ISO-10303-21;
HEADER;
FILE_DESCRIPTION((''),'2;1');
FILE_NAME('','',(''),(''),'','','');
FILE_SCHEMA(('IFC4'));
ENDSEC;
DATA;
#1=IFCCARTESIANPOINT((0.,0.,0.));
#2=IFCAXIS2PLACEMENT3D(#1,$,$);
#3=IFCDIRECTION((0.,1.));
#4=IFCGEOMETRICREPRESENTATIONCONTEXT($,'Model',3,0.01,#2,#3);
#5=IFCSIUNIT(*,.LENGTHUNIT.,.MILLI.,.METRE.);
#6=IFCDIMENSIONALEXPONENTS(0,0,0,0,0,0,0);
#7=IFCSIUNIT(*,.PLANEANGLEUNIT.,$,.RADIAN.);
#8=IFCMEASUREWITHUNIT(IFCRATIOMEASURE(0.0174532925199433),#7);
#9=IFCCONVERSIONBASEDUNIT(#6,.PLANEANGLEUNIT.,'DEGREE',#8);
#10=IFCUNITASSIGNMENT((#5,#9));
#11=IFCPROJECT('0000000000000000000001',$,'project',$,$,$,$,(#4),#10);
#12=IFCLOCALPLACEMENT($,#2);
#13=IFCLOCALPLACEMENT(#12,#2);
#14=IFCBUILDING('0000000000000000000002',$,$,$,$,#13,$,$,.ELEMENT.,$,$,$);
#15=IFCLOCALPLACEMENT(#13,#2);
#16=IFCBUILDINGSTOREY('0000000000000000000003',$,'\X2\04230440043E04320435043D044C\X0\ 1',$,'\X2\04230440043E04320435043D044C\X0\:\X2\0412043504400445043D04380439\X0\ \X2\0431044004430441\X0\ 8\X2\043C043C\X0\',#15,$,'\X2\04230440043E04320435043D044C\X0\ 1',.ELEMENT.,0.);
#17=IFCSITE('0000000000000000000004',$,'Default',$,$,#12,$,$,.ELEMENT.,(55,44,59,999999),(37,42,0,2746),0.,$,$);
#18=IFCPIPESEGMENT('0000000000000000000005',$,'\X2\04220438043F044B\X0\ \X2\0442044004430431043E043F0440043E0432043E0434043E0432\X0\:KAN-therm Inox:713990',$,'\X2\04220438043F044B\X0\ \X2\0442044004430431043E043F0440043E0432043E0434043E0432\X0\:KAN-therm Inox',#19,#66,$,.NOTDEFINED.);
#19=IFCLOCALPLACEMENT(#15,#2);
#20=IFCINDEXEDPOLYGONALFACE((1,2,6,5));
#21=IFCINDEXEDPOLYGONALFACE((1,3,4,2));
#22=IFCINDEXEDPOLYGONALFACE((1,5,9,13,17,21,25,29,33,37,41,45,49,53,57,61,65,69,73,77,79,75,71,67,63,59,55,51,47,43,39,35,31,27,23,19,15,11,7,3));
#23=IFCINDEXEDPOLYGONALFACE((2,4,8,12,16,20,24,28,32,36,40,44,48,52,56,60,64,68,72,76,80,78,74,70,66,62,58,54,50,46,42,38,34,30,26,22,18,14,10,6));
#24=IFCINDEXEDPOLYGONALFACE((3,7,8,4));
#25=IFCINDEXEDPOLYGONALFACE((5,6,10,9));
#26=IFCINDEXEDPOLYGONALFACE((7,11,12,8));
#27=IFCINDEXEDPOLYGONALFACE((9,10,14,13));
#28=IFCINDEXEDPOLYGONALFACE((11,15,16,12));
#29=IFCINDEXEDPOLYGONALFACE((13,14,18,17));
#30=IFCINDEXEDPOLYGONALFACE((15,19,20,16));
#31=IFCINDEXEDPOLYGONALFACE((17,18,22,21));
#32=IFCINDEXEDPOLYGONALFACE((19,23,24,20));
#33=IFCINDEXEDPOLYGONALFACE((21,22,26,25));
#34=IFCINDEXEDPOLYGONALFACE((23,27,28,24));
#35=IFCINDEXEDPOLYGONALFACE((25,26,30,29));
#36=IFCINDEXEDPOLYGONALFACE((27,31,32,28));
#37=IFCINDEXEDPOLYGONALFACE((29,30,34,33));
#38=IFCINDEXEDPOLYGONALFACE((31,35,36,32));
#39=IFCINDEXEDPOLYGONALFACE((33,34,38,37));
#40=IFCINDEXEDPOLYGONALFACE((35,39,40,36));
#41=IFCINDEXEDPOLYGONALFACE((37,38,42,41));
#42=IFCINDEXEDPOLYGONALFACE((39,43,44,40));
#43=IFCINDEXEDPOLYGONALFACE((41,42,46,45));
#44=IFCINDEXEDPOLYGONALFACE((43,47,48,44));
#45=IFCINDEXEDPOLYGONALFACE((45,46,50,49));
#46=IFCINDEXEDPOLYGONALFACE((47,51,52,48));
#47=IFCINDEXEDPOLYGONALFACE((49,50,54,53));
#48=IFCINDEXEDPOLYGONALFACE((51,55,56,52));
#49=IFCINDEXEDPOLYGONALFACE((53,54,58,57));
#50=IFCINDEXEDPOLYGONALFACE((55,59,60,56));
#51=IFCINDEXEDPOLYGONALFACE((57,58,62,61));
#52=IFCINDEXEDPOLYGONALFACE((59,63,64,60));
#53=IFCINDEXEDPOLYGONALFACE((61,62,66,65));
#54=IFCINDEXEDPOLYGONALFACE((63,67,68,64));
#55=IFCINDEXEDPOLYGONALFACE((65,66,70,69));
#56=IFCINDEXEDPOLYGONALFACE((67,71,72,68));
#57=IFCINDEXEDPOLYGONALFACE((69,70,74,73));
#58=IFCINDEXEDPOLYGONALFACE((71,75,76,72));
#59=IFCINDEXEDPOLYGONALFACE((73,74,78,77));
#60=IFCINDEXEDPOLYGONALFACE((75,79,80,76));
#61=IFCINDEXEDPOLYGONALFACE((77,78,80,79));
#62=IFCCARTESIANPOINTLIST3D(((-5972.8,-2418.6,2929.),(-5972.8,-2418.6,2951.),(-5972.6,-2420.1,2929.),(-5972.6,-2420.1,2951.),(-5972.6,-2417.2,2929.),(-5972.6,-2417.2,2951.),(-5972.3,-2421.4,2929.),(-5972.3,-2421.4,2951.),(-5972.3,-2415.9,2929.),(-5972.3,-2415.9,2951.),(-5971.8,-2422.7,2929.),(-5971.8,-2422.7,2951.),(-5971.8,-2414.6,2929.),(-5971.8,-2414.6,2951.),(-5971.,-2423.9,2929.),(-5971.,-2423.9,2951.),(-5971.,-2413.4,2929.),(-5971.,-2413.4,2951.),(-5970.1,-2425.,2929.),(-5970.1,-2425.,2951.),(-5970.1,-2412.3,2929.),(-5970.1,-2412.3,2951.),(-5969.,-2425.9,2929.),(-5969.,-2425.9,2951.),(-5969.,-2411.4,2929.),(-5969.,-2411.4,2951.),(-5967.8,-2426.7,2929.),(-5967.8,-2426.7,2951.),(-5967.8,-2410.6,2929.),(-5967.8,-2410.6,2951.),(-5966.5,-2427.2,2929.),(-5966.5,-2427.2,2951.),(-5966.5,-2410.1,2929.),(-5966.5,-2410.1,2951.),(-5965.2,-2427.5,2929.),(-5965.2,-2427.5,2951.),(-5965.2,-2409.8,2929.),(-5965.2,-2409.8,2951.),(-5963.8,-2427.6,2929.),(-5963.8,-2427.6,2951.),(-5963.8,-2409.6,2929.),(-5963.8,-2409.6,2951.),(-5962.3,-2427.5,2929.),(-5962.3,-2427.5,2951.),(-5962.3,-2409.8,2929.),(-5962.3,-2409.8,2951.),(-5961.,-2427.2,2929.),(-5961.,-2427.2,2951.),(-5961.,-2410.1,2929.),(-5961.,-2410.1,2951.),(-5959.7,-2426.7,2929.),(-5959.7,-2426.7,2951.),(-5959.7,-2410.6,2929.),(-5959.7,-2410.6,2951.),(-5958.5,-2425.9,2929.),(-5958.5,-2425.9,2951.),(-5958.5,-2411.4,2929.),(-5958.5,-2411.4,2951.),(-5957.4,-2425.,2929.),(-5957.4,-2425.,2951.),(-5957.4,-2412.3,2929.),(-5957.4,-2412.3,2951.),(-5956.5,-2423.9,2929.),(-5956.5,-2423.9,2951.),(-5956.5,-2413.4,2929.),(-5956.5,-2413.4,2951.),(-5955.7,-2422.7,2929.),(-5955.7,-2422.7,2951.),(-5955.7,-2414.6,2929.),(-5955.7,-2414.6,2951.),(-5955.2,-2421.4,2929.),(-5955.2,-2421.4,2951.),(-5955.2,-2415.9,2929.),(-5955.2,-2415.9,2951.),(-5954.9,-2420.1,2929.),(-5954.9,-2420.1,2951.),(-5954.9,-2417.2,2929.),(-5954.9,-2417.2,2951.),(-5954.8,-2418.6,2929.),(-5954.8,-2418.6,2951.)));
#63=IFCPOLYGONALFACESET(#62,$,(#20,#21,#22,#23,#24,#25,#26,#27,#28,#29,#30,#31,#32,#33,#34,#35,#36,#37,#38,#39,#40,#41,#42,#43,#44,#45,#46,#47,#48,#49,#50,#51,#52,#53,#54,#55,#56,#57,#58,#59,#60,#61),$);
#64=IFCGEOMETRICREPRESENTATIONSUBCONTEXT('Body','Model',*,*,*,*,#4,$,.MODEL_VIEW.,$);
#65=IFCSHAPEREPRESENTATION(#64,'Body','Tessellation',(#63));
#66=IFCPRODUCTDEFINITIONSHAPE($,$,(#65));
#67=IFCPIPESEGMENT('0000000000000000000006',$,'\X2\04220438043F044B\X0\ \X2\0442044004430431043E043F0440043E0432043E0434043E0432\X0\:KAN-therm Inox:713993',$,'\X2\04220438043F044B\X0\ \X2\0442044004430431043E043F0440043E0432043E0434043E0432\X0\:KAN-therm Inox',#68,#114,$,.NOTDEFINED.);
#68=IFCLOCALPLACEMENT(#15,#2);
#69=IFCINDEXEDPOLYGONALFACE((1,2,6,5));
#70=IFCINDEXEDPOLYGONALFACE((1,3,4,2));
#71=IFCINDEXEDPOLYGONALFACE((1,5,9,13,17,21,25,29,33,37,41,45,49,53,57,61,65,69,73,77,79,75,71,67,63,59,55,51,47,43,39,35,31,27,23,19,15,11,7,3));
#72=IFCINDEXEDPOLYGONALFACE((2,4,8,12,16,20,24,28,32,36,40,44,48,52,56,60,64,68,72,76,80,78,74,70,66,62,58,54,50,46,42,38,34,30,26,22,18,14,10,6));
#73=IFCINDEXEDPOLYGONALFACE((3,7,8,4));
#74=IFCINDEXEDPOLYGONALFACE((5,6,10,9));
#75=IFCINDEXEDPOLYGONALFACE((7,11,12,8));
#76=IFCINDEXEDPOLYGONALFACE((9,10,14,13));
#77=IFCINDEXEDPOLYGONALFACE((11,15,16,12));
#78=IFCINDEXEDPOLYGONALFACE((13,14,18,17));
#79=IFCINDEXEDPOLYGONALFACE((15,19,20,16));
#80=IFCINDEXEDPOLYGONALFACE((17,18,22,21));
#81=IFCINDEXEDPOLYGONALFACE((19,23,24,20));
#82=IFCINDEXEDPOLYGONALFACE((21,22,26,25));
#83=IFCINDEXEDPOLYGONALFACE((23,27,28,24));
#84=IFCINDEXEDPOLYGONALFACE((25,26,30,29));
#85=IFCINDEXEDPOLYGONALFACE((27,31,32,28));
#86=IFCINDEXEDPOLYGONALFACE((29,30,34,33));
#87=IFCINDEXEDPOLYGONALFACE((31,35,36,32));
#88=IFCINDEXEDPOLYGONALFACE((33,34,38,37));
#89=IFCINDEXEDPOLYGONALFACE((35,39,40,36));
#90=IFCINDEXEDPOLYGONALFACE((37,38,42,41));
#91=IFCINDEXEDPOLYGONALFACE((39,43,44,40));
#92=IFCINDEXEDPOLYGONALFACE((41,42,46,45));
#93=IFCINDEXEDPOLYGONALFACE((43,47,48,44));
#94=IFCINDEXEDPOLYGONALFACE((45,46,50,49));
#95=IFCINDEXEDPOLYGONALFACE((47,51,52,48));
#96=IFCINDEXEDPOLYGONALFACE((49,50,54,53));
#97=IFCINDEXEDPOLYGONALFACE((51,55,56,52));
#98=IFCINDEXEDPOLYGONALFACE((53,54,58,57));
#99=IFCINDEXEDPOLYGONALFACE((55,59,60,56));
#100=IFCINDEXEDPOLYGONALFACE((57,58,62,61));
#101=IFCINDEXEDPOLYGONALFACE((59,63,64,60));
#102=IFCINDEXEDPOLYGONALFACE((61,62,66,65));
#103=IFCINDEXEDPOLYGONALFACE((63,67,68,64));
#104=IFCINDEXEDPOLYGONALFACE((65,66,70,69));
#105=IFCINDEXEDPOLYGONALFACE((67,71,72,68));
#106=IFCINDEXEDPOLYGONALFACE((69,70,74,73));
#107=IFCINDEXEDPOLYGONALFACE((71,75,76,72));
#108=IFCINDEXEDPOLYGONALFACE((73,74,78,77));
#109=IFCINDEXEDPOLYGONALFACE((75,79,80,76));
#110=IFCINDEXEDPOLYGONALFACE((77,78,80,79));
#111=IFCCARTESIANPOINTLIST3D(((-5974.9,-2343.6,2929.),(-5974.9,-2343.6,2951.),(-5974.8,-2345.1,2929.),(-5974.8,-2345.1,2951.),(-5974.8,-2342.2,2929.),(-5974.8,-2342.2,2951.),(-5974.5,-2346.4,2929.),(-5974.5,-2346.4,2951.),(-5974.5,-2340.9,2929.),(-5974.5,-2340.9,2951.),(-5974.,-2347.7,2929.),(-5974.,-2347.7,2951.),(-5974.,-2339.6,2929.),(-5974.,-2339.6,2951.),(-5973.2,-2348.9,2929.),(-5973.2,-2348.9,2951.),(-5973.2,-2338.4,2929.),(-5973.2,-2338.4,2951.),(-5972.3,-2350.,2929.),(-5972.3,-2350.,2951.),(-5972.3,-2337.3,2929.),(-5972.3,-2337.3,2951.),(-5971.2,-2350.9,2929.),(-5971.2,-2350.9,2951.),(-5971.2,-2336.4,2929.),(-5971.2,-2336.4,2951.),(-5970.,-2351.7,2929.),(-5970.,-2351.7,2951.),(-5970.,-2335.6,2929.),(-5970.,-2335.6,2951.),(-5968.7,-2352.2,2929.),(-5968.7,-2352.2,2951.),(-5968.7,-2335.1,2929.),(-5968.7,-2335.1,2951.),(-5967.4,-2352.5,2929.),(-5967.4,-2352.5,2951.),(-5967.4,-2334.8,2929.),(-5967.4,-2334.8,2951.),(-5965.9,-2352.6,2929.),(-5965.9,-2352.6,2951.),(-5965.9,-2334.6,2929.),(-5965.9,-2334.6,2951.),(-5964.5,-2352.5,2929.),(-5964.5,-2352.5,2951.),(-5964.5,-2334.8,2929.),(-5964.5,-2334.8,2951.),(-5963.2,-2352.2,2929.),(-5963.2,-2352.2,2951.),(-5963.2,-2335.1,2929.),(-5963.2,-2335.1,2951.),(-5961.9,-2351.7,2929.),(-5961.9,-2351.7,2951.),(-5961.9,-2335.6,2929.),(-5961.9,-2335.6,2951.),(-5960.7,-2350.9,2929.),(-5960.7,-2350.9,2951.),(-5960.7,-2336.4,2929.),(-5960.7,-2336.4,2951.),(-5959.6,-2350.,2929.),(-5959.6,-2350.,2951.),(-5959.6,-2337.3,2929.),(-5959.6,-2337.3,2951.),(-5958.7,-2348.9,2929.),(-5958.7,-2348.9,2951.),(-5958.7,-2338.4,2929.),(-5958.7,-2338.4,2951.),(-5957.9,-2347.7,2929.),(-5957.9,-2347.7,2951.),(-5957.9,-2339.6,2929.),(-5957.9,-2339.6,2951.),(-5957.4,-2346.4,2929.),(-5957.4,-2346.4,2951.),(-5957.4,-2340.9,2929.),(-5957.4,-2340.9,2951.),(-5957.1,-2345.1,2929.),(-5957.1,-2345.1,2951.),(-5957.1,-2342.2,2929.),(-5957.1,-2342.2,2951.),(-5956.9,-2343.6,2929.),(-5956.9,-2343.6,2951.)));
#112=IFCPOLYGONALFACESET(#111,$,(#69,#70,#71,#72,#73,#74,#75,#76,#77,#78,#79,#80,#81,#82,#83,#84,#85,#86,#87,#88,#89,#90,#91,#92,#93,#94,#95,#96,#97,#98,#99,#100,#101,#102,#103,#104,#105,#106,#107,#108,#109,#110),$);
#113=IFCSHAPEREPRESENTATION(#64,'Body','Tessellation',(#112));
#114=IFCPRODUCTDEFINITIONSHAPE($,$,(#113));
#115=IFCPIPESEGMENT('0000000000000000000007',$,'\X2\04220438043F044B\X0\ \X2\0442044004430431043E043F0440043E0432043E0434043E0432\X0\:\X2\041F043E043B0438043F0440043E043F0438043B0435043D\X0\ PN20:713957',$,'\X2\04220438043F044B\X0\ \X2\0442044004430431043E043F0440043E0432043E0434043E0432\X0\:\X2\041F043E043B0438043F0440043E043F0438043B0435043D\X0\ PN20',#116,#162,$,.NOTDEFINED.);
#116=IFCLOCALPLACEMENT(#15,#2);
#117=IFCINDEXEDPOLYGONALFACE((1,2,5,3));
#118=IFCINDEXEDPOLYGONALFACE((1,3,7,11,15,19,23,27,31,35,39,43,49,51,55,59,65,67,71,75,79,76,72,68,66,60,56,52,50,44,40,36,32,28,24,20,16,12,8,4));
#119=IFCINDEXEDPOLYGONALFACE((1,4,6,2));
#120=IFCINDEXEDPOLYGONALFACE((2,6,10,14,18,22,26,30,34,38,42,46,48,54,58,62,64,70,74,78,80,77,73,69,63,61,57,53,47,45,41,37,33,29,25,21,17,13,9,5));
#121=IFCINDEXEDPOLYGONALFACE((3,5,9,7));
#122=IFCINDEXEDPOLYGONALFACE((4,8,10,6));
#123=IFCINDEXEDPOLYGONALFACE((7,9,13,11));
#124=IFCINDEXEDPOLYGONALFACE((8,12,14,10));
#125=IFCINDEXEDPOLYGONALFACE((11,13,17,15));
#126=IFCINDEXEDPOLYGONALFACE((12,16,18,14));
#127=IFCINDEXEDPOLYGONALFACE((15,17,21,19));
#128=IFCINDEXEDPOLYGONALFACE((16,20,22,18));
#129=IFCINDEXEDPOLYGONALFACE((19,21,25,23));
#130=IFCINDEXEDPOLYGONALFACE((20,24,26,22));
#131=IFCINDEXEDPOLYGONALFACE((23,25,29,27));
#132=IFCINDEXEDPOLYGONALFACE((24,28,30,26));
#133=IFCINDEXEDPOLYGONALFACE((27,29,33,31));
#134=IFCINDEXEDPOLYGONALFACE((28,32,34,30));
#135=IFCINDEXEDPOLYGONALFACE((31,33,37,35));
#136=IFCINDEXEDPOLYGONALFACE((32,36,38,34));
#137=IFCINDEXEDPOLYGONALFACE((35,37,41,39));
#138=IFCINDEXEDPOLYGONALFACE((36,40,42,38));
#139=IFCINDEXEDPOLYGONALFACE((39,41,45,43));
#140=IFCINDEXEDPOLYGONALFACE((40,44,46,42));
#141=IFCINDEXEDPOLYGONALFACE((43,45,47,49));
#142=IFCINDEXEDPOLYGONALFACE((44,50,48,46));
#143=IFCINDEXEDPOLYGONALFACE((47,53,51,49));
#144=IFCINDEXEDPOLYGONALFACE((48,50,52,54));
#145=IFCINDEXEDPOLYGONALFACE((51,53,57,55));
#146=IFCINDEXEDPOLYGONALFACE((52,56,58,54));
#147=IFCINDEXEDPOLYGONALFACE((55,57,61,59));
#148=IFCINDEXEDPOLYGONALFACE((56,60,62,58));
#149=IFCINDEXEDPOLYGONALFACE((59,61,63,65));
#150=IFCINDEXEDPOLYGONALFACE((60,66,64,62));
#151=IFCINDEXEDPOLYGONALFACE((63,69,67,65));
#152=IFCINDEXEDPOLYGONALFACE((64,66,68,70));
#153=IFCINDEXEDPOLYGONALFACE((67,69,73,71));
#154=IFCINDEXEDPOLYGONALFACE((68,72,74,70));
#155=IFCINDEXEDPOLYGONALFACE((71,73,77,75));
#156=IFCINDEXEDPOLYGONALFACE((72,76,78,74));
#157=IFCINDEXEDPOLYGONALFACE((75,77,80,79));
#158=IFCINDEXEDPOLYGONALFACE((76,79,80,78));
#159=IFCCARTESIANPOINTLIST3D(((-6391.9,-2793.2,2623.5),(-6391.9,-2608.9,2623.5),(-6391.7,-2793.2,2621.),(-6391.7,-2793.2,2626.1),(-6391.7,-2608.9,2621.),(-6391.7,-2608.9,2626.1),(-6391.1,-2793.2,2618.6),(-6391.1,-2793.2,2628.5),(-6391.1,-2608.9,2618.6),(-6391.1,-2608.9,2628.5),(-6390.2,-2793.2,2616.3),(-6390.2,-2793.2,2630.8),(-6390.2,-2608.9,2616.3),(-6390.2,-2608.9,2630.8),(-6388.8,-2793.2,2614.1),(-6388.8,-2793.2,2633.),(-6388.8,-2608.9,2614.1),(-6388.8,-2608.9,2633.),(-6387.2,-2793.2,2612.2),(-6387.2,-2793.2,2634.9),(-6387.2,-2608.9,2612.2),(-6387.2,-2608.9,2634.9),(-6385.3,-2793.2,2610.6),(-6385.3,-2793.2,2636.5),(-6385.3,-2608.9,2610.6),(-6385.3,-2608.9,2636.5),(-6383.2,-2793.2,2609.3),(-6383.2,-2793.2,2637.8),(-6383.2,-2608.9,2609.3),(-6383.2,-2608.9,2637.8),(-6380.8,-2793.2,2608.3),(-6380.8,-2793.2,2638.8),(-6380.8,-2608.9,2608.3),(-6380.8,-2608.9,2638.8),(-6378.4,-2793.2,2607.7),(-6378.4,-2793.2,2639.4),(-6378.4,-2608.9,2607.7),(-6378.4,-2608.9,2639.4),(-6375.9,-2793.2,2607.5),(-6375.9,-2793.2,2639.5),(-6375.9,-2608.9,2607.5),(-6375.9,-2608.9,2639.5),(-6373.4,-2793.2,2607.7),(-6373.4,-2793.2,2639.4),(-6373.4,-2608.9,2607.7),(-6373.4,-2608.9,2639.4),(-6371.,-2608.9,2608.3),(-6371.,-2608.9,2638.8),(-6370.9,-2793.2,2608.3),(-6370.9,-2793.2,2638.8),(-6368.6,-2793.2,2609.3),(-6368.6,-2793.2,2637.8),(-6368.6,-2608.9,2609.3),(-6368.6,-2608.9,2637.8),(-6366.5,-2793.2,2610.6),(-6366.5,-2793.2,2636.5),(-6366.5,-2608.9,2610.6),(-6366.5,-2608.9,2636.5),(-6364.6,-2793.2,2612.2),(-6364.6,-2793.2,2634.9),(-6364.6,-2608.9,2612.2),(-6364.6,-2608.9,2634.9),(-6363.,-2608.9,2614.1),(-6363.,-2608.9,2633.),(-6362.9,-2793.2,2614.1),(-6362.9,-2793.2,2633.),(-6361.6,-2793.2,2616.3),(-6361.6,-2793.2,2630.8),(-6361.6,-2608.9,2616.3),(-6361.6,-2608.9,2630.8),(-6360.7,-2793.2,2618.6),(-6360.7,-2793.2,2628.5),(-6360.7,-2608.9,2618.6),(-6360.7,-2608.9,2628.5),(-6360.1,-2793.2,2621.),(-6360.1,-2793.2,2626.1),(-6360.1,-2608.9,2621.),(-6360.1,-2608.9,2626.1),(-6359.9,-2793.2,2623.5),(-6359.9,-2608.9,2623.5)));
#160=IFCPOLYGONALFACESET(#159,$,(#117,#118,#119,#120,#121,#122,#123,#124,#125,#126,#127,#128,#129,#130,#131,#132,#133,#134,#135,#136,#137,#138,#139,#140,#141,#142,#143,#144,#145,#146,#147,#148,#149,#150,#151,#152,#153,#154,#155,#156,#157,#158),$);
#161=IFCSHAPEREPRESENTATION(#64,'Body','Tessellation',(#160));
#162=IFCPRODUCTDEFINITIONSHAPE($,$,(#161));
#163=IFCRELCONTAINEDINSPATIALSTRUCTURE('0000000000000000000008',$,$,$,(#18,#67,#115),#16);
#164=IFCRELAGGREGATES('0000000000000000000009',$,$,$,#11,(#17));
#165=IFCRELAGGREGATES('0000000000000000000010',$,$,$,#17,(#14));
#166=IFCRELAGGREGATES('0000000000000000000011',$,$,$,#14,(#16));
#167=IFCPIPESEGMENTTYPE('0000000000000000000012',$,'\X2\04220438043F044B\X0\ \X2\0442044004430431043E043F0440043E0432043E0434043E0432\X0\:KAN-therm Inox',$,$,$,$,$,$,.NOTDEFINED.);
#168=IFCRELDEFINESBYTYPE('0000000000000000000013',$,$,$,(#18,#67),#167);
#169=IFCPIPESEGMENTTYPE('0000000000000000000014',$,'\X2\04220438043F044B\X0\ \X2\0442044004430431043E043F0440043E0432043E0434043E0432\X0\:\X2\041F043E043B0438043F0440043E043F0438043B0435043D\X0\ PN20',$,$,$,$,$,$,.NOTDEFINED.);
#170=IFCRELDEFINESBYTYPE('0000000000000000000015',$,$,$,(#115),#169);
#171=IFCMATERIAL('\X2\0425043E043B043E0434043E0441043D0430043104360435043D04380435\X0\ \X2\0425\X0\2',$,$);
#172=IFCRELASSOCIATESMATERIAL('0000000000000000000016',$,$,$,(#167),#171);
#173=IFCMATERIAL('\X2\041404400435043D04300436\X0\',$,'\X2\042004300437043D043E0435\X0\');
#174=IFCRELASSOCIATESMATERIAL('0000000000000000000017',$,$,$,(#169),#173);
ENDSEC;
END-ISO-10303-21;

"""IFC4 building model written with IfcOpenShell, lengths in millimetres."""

from ifc_helpers import new_model, entity, si_unit, converted_unit, direction, frame, origin, place, context, subcontext, project, spatial, indexed_curve, outline, extrude, material, type_object, element, save


model = new_model("IFC4")

# Units and contexts
model_context = context("Model", 3, precision=0.01, world=origin(), true_north=direction((0.0, 1.0)))
body_context = subcontext(model_context, "Body", "Model", "MODEL_VIEW")
ifc_project = project(units=[si_unit("LENGTHUNIT", "METRE", prefix="MILLI"), converted_unit("PLANEANGLEUNIT", "DEGREE", entity("IfcRatioMeasure", 0.0174532925199433), si_unit("PLANEANGLEUNIT", "RADIAN"), dimensions=[0, 0, 0, 0, 0, 0, 0])], contexts=[model_context])

# Site, building, storey
site_placement = place(None, origin())
site = spatial("IfcSite", under=ifc_project, at=site_placement, Name="Default", CompositionType="ELEMENT", RefLatitude=(55, 44, 59, 999999), RefLongitude=(37, 42, 0, 2746), RefElevation=0.0)
building_placement = place(site_placement, origin())
building = spatial("IfcBuilding", under=site, at=building_placement, CompositionType="ELEMENT")
storey_placement = place(building_placement, origin())
storey = spatial("IfcBuildingStorey", under=building, at=storey_placement, Name="Уровень 1", ObjectType="Уровень:Верхний брус 8мм", LongName="Уровень 1", CompositionType="ELEMENT", Elevation=0.0)

# Shared definitions
ifc_material_1 = material(Name="Холодоснабжение Х2")

# Shared definitions
pipe_segment_type_1 = type_object("IfcPipeSegmentType", Name="Типы трубопроводов:KAN-therm Inox", PredefinedType="NOTDEFINED", material=ifc_material_1)

# Pipe segments
pipe_segment_1_placement = place(storey_placement, origin())
element("IfcPipeSegment", 1, at=pipe_segment_1_placement, inside=storey, type_object=pipe_segment_type_1, Name="Типы трубопроводов:KAN-therm Inox:713990", ObjectType="Типы трубопроводов:KAN-therm Inox", PredefinedType="NOTDEFINED", context=body_context, shape_type="SweptSolid", body=[
    extrude(outline(indexed_curve([(9.0, 0.0), (8.9, 1.4), (8.6, 2.8), (8.0, 4.1), (7.3, 5.3), (6.4, 6.4), (5.3, 7.3), (4.1, 8.0), (2.8, 8.6), (1.4, 8.9), (0.0, 9.0), (-1.4, 8.9), (-2.8, 8.6), (-4.1, 8.0), (-5.3, 7.3), (-6.4, 6.4), (-7.3, 5.3), (-8.0, 4.1), (-8.6, 2.8), (-8.9, 1.4), (-9.0, 0.0), (-8.9, -1.4), (-8.6, -2.8), (-8.0, -4.1), (-7.3, -5.3), (-6.4, -6.4), (-5.3, -7.3), (-4.1, -8.0), (-2.8, -8.6), (-1.4, -8.9), (0.0, -9.0), (1.4, -8.9), (2.8, -8.6), (4.1, -8.0), (5.3, -7.3), (6.4, -6.4), (7.3, -5.3), (8.0, -4.1), (8.6, -2.8), (8.9, -1.4), (9.0, 0.0)], self_intersect=False)), frame((-5963.8, -2418.6, 2929.0), z_axis=(0.0, 0.0, 1.0), x_axis=(-1.0, 0.0, 0.0)), (0.0, 0.0, 1.0), 22.0),
])
pipe_segment_2_placement = place(storey_placement, origin())
element("IfcPipeSegment", 2, at=pipe_segment_2_placement, inside=storey, type_object=pipe_segment_type_1, Name="Типы трубопроводов:KAN-therm Inox:713993", ObjectType="Типы трубопроводов:KAN-therm Inox", PredefinedType="NOTDEFINED", context=body_context, shape_type="SweptSolid", body=[
    extrude(outline(indexed_curve([(9.0, 0.0), (8.9, 1.4), (8.6, 2.8), (8.0, 4.1), (7.3, 5.3), (6.4, 6.4), (5.3, 7.3), (4.1, 8.0), (2.8, 8.6), (1.4, 8.9), (0.0, 9.0), (-1.4, 8.9), (-2.8, 8.6), (-4.1, 8.0), (-5.3, 7.3), (-6.4, 6.4), (-7.3, 5.3), (-8.0, 4.1), (-8.6, 2.8), (-8.9, 1.4), (-9.0, 0.0), (-8.9, -1.4), (-8.6, -2.8), (-8.0, -4.1), (-7.3, -5.3), (-6.4, -6.4), (-5.3, -7.3), (-4.1, -8.0), (-2.8, -8.6), (-1.4, -8.9), (0.0, -9.0), (1.4, -8.9), (2.8, -8.6), (4.1, -8.0), (5.3, -7.3), (6.4, -6.4), (7.3, -5.3), (8.0, -4.1), (8.6, -2.8), (8.9, -1.4), (9.0, 0.0)], self_intersect=False)), frame((-5965.9, -2343.6, 2929.0), z_axis=(0.0, 0.0, 1.0), x_axis=(-1.0, 0.0, 0.0)), (0.0, 0.0, 1.0), 22.0),
])
ifc_material_2 = material(Name="Дренаж", Category="Разное")
pipe_segment_type_2 = type_object("IfcPipeSegmentType", Name="Типы трубопроводов:Полипропилен PN20", PredefinedType="NOTDEFINED", material=ifc_material_2)
pipe_segment_3_placement = place(storey_placement, origin())
element("IfcPipeSegment", 3, at=pipe_segment_3_placement, inside=storey, type_object=pipe_segment_type_2, Name="Типы трубопроводов:Полипропилен PN20:713957", ObjectType="Типы трубопроводов:Полипропилен PN20", PredefinedType="NOTDEFINED", context=body_context, shape_type="SweptSolid", body=[
    extrude(outline(indexed_curve([(16.0, 0.0), (15.8, 2.5), (15.2, 4.9), (14.3, 7.3), (12.9, 9.4), (11.3, 11.3), (9.4, 12.9), (7.3, 14.3), (4.9, 15.2), (2.5, 15.8), (0.0, 16.0), (-2.5, 15.8), (-4.9, 15.2), (-7.3, 14.3), (-9.4, 12.9), (-11.3, 11.3), (-12.9, 9.4), (-14.3, 7.3), (-15.2, 4.9), (-15.8, 2.5), (-16.0, 0.0), (-15.8, -2.5), (-15.2, -4.9), (-14.3, -7.3), (-12.9, -9.4), (-11.3, -11.3), (-9.4, -12.9), (-7.3, -14.3), (-4.9, -15.2), (-2.5, -15.8), (0.0, -16.0), (2.5, -15.8), (4.9, -15.2), (7.3, -14.3), (9.4, -12.9), (11.3, -11.3), (12.9, -9.4), (14.3, -7.3), (15.2, -4.9), (15.8, -2.5), (16.0, 0.0)], self_intersect=False)), frame((-6375.9, -2793.2, 2623.5), z_axis=(-0.000002, 1.0, 0.0), x_axis=(1.0, 0.000002, 0.0)), (0.0, 0.0, 1.0), 184.3),
])

save(model, "model.ifc")
